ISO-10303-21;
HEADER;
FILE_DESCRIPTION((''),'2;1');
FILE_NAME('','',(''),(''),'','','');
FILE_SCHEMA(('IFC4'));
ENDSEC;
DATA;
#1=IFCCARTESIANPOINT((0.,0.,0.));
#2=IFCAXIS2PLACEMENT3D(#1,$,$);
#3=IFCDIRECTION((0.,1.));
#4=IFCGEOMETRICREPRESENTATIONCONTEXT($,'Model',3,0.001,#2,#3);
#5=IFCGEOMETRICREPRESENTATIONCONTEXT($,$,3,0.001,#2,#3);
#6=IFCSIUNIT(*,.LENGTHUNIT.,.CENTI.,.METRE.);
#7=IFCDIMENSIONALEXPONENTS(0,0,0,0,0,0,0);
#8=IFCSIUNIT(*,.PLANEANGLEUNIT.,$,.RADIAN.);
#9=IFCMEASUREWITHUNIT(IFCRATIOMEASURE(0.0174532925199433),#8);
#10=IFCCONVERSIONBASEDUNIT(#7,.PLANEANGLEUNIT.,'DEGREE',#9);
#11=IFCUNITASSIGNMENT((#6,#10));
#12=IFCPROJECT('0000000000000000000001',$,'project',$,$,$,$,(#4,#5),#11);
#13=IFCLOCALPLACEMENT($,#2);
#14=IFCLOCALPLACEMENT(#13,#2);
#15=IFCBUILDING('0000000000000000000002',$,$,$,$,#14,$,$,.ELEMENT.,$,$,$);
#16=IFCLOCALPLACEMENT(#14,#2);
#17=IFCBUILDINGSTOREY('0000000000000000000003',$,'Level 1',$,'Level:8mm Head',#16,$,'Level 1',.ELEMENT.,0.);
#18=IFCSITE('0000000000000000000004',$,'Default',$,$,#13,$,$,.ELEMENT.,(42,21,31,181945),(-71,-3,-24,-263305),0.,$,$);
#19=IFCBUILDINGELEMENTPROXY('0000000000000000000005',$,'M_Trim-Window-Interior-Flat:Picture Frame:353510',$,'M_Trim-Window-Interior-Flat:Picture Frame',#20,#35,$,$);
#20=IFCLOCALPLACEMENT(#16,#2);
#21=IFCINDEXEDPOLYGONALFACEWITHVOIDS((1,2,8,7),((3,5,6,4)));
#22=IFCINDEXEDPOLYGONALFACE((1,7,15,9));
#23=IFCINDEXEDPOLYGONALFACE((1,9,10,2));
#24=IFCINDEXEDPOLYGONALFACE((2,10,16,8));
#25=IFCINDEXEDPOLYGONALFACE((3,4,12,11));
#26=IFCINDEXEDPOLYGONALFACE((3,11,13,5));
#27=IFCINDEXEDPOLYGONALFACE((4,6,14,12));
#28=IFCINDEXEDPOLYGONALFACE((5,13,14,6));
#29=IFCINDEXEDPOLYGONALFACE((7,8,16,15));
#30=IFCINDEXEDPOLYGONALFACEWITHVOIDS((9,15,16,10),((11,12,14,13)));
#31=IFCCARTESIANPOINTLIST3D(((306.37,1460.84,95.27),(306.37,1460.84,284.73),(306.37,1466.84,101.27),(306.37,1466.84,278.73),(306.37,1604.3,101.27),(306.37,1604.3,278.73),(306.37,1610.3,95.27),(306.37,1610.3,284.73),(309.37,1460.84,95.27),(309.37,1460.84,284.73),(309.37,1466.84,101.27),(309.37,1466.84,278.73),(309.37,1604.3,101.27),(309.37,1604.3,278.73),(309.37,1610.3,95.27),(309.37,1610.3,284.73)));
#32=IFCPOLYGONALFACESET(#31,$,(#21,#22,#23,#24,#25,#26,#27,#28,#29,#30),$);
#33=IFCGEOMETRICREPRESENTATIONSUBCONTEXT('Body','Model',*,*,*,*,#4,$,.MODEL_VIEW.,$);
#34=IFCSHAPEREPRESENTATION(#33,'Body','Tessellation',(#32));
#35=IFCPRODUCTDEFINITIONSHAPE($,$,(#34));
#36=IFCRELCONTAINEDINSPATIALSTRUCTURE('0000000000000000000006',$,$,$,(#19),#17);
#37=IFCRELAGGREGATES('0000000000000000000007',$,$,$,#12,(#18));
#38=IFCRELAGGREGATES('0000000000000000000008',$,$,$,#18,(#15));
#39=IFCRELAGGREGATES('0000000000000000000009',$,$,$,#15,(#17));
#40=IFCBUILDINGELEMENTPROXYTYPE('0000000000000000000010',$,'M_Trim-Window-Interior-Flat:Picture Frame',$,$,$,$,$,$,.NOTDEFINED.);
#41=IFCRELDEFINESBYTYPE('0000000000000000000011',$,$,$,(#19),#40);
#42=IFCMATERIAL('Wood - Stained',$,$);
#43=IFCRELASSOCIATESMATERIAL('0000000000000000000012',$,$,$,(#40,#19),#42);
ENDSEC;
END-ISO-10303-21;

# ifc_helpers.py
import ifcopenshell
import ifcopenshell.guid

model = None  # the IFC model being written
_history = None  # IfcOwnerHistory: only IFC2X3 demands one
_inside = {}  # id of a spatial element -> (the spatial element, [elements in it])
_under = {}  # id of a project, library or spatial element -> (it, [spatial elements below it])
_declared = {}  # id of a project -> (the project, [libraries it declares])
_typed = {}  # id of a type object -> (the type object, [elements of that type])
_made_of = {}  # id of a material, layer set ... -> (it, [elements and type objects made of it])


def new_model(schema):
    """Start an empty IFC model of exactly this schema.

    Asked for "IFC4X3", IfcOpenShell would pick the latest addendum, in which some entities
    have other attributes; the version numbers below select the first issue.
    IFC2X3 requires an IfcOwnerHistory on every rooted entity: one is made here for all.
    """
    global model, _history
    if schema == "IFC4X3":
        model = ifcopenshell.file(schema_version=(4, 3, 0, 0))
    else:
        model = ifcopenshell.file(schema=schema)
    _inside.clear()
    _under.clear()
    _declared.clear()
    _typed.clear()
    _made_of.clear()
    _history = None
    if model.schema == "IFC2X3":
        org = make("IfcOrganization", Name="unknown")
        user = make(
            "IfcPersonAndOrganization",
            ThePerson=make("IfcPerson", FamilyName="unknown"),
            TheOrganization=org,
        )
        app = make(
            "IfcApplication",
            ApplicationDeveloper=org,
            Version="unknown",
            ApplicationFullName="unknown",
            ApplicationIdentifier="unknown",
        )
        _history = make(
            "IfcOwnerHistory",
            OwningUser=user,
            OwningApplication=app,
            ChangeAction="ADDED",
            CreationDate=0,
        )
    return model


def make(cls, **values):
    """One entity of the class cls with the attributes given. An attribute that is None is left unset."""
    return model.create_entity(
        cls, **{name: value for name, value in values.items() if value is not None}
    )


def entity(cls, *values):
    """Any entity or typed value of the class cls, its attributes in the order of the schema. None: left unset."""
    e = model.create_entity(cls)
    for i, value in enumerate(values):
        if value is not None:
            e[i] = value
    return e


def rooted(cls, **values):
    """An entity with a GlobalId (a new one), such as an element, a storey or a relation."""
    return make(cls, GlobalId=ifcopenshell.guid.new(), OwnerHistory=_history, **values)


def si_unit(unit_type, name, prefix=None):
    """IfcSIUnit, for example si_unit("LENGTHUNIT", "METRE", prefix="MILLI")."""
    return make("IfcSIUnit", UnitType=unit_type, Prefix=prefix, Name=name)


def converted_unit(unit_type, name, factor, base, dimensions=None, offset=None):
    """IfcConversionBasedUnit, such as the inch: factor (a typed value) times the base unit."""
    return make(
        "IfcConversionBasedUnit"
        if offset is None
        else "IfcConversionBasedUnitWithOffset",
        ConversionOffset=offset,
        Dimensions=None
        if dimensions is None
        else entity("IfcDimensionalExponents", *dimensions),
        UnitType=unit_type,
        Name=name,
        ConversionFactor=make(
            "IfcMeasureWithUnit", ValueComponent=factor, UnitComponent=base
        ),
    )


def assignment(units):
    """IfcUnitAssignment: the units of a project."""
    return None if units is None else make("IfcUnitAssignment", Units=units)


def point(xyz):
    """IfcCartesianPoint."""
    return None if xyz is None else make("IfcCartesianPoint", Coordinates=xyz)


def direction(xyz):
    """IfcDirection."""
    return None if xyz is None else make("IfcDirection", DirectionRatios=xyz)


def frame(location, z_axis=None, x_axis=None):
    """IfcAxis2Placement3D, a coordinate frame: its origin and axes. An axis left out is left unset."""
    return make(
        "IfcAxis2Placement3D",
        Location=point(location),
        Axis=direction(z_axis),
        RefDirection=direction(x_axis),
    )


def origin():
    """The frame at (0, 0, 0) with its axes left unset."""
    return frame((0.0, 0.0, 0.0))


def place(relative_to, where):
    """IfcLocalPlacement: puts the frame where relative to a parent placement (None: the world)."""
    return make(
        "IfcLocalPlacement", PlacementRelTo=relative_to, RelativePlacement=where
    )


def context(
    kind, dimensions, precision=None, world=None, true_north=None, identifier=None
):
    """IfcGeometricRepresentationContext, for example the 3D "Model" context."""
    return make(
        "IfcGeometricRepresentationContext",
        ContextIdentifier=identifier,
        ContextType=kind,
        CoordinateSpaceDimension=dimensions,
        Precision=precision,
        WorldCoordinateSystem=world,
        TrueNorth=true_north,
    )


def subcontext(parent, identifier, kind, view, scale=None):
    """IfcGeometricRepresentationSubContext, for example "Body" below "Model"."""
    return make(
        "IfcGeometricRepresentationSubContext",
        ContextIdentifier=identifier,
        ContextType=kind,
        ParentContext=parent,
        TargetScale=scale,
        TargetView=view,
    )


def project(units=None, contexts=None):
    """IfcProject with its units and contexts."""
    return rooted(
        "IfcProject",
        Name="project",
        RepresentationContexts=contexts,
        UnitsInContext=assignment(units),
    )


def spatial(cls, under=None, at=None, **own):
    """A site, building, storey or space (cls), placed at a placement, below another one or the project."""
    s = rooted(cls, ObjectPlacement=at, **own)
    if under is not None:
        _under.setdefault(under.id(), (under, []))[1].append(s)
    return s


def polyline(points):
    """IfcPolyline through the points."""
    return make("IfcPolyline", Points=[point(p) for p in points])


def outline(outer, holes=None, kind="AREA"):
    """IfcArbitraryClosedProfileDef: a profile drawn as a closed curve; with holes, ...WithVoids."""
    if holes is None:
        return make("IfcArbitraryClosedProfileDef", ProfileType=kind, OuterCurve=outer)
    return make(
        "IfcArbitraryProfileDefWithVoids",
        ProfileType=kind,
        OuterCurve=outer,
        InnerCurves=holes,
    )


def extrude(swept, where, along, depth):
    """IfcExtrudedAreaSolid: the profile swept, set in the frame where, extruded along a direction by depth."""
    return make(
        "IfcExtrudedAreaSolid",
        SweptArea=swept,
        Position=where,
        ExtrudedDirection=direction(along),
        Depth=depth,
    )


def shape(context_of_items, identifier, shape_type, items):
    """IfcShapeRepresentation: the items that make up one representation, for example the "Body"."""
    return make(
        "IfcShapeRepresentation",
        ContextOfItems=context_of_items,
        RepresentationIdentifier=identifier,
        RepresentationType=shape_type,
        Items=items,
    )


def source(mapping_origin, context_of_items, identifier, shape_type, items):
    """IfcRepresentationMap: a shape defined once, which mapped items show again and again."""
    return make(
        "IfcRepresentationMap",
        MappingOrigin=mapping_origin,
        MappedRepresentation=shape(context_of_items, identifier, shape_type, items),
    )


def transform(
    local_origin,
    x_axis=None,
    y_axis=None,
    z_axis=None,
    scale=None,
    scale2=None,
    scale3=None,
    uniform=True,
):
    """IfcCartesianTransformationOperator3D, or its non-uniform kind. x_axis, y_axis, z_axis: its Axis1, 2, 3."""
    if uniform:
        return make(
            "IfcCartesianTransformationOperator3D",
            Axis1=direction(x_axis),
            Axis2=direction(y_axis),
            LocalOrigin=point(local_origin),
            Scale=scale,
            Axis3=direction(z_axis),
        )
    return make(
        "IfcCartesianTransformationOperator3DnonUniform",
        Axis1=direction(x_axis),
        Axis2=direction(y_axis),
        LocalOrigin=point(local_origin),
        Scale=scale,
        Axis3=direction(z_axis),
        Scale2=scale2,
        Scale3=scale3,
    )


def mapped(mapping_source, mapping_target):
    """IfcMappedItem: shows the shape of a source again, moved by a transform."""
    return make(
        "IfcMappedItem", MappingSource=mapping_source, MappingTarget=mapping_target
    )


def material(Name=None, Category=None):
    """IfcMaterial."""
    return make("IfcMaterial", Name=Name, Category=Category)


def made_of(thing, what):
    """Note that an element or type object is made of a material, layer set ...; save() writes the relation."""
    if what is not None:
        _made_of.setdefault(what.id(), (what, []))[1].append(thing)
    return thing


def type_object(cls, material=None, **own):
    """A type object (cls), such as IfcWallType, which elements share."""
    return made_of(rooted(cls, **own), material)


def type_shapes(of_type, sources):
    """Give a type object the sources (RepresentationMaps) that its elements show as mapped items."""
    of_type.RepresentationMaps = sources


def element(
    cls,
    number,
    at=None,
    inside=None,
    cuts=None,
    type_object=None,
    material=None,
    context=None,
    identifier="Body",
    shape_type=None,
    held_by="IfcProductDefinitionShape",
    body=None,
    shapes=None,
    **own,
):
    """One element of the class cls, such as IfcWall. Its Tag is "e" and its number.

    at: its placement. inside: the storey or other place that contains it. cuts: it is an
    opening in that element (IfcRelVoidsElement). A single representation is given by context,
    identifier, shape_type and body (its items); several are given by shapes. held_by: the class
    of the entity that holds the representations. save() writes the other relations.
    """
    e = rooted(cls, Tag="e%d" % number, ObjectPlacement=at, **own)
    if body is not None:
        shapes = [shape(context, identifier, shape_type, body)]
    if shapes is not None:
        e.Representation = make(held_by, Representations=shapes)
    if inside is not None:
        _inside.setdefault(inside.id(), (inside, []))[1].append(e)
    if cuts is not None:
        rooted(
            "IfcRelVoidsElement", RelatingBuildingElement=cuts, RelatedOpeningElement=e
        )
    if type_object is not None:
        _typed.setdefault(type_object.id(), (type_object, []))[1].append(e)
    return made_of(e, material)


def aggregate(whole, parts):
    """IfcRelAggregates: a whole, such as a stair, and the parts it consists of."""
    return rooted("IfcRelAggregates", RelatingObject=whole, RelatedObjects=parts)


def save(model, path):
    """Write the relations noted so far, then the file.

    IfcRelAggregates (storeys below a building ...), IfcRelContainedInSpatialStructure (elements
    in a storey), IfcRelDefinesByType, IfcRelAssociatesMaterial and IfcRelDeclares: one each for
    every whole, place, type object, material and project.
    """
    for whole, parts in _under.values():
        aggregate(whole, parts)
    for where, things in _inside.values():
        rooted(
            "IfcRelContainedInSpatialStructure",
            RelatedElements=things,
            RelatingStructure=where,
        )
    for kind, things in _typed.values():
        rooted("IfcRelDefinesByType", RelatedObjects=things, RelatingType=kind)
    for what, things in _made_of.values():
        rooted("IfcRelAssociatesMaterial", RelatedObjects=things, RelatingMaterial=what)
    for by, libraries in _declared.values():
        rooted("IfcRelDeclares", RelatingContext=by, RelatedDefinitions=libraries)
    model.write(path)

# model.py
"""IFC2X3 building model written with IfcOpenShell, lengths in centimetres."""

from ifc_helpers import new_model, entity, si_unit, converted_unit, direction, frame, origin, place, context, subcontext, project, spatial, polyline, outline, extrude, source, transform, mapped, material, type_object, type_shapes, element, save


model = new_model("IFC2X3")

# Units and contexts
model_context = context("Model", 3, precision=0.001, world=origin(), true_north=direction((0.0, 1.0)))
context_of_model = context(None, 3, precision=0.001, world=origin(), true_north=direction((0.0, 1.0)))
body_context = subcontext(model_context, "Body", "Model", "MODEL_VIEW")
ifc_project = project(units=[si_unit("LENGTHUNIT", "METRE", prefix="CENTI"), converted_unit("PLANEANGLEUNIT", "DEGREE", entity("IfcRatioMeasure", 0.0174532925199433), si_unit("PLANEANGLEUNIT", "RADIAN"), dimensions=[0, 0, 0, 0, 0, 0, 0])], contexts=[model_context, context_of_model])

# Site, building, storey
site_placement = place(None, origin())
site = spatial("IfcSite", under=ifc_project, at=site_placement, Name="Default", CompositionType="ELEMENT", RefLatitude=(42, 21, 31, 181945), RefLongitude=(-71, -3, -24, -263305), RefElevation=0.0)
building_placement = place(site_placement, origin())
building = spatial("IfcBuilding", under=site, at=building_placement, CompositionType="ELEMENT")
storey_placement = place(building_placement, origin())
storey = spatial("IfcBuildingStorey", under=building, at=storey_placement, Name="Level 1", ObjectType="Level:8mm Head", LongName="Level 1", CompositionType="ELEMENT", Elevation=0.0)

# Building element proxy
ifc_material_1 = material(Name="Wood - Stained")
building_element_proxy_type_1 = type_object("IfcBuildingElementProxyType", Name="M_Trim-Window-Interior-Flat:Picture Frame", PredefinedType="NOTDEFINED", material=ifc_material_1)
shared_shape_1 = source(origin(), body_context, "Body", "SweptSolid", [
    extrude(outline(polyline([(-94.73, -74.73), (94.73, -74.73), (94.73, 74.73), (-94.73, 74.73), (-94.73, -74.73)]), holes=[polyline([(-88.73, -68.73), (-88.73, 68.73), (88.73, 68.73), (88.73, -68.73), (-88.73, -68.73)])]), frame((0.0, 90.0, 0.0), z_axis=(0.0, 0.0, 1.0), x_axis=(0.0, 1.0, 0.0)), (0.0, 0.0, 1.0), 3.0),
])
type_shapes(building_element_proxy_type_1, [shared_shape_1])
proxy_1_placement = place(storey_placement, frame((309.37, 1535.57, 280.0), z_axis=(-1.0, 0.0, 0.0), x_axis=(0.0, 1.0, 0.0)))
element("IfcBuildingElementProxy", 1, at=proxy_1_placement, inside=storey, type_object=building_element_proxy_type_1, material=ifc_material_1, Name="M_Trim-Window-Interior-Flat:Picture Frame:353510", ObjectType="M_Trim-Window-Interior-Flat:Picture Frame", context=body_context, shape_type="MappedRepresentation", body=[
    mapped(shared_shape_1, transform((0.0, 0.0, 0.0), scale=1.0)),
])

save(model, "model.ifc")
